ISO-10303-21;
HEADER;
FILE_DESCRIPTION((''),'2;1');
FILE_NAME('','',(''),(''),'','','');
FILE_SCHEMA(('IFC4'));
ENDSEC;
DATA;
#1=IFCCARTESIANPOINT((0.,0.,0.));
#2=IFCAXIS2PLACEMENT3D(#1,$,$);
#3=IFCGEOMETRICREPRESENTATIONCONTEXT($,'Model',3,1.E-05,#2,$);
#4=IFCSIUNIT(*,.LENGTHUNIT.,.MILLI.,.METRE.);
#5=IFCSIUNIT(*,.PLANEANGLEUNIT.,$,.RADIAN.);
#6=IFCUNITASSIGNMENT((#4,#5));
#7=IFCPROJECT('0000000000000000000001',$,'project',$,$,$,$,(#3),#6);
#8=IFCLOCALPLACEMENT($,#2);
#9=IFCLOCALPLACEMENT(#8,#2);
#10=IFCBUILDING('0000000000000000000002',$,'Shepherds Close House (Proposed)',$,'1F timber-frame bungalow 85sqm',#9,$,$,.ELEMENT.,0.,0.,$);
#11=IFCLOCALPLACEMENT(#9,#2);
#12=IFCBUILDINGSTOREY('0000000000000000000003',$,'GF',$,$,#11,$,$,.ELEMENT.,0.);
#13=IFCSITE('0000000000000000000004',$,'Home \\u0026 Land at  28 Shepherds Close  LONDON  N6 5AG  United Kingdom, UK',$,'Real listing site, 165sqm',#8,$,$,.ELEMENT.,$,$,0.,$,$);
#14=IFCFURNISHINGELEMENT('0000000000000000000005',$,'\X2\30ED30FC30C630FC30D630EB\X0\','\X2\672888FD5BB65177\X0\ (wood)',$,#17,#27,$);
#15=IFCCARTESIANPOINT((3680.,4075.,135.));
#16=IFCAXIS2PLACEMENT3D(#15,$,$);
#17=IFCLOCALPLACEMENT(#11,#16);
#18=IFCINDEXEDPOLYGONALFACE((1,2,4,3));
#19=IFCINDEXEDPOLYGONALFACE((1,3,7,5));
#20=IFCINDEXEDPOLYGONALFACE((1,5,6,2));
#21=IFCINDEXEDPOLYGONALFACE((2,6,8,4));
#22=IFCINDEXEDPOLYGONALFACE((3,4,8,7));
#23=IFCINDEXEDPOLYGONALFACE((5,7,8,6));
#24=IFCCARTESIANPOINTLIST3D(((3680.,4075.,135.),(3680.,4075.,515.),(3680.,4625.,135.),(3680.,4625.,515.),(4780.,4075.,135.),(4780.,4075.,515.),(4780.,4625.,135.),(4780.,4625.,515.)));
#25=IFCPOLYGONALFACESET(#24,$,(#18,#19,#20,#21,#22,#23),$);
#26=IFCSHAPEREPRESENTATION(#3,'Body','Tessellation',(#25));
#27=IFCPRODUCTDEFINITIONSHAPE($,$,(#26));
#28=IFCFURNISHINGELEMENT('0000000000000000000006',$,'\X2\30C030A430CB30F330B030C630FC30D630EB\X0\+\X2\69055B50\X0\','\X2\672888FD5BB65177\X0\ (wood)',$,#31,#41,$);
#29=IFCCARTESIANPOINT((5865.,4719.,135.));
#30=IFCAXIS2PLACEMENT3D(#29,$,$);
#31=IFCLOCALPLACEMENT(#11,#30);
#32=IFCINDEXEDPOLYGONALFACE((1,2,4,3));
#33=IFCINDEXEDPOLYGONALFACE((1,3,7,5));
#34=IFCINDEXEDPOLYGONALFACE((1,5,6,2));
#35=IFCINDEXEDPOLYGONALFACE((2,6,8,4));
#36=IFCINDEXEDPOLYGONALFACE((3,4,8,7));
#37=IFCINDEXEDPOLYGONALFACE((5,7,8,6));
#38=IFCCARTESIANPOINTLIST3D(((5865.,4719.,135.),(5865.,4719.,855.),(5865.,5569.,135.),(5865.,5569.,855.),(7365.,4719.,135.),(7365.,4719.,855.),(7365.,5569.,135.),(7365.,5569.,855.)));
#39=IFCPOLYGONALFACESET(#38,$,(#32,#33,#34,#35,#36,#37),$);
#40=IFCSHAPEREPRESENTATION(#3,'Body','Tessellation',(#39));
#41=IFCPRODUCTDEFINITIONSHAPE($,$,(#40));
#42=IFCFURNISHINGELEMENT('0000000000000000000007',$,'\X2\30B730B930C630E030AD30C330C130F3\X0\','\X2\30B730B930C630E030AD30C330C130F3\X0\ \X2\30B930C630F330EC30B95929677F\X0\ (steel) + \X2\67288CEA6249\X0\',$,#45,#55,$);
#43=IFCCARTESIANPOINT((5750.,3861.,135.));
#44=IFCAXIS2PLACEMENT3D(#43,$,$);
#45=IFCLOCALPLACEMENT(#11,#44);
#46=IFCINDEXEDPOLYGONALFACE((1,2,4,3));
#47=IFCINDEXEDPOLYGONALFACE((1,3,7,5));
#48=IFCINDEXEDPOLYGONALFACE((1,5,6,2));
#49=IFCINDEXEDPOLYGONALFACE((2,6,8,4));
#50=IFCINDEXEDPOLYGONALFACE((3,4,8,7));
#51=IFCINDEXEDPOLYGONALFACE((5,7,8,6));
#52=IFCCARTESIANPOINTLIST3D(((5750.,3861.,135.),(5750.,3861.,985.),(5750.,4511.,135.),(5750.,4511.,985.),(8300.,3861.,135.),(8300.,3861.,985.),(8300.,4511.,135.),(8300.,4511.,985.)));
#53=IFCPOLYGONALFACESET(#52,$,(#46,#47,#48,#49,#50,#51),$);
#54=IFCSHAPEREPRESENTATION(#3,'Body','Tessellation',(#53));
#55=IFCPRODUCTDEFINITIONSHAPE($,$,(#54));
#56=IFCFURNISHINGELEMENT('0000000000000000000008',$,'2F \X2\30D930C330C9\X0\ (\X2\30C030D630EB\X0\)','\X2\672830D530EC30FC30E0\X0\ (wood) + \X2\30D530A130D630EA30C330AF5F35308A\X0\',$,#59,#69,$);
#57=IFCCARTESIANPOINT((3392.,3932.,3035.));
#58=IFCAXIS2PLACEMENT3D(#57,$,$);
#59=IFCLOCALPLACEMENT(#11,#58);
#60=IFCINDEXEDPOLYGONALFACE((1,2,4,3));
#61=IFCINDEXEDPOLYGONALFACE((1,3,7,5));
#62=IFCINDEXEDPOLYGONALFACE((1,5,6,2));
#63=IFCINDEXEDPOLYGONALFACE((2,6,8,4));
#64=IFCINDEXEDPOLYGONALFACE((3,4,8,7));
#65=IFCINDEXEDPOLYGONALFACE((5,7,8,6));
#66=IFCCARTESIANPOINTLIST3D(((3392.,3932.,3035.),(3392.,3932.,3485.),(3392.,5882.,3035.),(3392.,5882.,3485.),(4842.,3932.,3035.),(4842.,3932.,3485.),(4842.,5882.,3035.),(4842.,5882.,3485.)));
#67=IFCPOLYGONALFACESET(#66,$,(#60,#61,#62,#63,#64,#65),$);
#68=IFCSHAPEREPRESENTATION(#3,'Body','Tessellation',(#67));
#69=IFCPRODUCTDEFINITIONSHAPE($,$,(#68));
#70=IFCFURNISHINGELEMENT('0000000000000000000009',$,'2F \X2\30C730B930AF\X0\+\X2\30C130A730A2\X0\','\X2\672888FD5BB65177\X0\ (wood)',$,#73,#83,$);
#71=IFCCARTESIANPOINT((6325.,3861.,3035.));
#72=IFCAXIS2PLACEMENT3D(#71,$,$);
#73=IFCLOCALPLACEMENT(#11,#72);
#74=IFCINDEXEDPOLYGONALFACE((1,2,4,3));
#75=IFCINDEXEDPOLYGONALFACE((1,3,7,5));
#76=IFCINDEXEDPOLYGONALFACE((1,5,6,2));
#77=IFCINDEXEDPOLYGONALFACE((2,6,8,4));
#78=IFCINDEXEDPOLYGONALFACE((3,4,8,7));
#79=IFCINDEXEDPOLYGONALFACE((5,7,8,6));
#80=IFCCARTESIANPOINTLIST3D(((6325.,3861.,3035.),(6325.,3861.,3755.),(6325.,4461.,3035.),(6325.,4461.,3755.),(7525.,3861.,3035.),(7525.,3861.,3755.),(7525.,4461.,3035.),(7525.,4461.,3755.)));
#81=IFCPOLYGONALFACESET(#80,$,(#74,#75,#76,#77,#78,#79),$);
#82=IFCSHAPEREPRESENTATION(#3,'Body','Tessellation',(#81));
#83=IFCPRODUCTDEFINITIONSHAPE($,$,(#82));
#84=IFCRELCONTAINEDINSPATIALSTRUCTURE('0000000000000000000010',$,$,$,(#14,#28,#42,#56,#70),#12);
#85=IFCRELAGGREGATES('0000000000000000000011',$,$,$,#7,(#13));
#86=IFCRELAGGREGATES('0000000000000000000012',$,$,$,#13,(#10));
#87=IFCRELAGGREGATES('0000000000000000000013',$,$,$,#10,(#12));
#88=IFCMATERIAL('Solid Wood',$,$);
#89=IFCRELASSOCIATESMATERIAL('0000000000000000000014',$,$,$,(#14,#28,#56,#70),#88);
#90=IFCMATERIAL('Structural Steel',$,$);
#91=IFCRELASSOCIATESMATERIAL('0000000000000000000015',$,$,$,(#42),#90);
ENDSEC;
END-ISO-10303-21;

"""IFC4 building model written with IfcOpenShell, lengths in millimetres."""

from ifc_helpers import new_model, si_unit, frame, frame_2d, origin, place, context, project, spatial, rectangle, extrude, material, element, save


model = new_model("IFC4")

# Units and contexts
model_context = context("Model", 3, precision=1e-05, world=origin())
ifc_project = project(units=[si_unit("LENGTHUNIT", "METRE", prefix="MILLI"), si_unit("PLANEANGLEUNIT", "RADIAN")], contexts=[model_context])

# Site, building, storey
site_placement = place(None, origin())
site = spatial("IfcSite", under=ifc_project, at=site_placement, Name="Home \\u0026 Land at  28 Shepherds Close  LONDON  N6 5AG  United Kingdom, UK", ObjectType="Real listing site, 165sqm", CompositionType="ELEMENT", RefElevation=0.0)
building_placement = place(site_placement, origin())
building = spatial("IfcBuilding", under=site, at=building_placement, Name="Shepherds Close House (Proposed)", ObjectType="1F timber-frame bungalow 85sqm", CompositionType="ELEMENT", ElevationOfRefHeight=0.0, ElevationOfTerrain=0.0)
storey_placement = place(building_placement, origin())
storey = spatial("IfcBuildingStorey", under=building, at=storey_placement, Name="GF", CompositionType="ELEMENT", Elevation=0.0)

# Shared definitions
ifc_material_1 = material(Name="Solid Wood")

# Shared definitions
ifc_material_2 = material(Name="Structural Steel")

# Furnishing elements
furnishing_1_placement = place(storey_placement, frame((3680.0, 4075.0, 135.0)))
element("IfcFurnishingElement", 1, at=furnishing_1_placement, inside=storey, material=ifc_material_1, Name="ローテーブル", Description="木製家具 (wood)", context=model_context, shape_type="SweptSolid", body=[
    extrude(rectangle(XDim=1100.0, YDim=550.0, at=frame_2d((550.0, 275.0))), frame((3680.0, 4075.0, 135.0)), (0.0, 0.0, 1.0), 380.0),
])
furnishing_2_placement = place(storey_placement, frame((5865.0, 4719.0, 135.0)))
element("IfcFurnishingElement", 2, at=furnishing_2_placement, inside=storey, material=ifc_material_1, Name="ダイニングテーブル+椅子", Description="木製家具 (wood)", context=model_context, shape_type="SweptSolid", body=[
    extrude(rectangle(XDim=1500.0, YDim=850.0, at=frame_2d((750.0, 425.0))), frame((5865.0, 4719.0, 135.0)), (0.0, 0.0, 1.0), 720.0),
])
furnishing_3_placement = place(storey_placement, frame((5750.0, 3861.0, 135.0)))
element("IfcFurnishingElement", 3, at=furnishing_3_placement, inside=storey, material=ifc_material_2, Name="システムキッチン", Description="システムキッチン ステンレス天板 (steel) + 木質扉", context=model_context, shape_type="SweptSolid", body=[
    extrude(rectangle(XDim=2550.0, YDim=650.0, at=frame_2d((1275.0, 325.0))), frame((5750.0, 3861.0, 135.0)), (0.0, 0.0, 1.0), 850.0),
])
furnishing_4_placement = place(storey_placement, frame((3392.0, 3932.0, 3035.0)))
element("IfcFurnishingElement", 4, at=furnishing_4_placement, inside=storey, material=ifc_material_1, Name="2F ベッド (ダブル)", Description="木フレーム (wood) + ファブリック張り", context=model_context, shape_type="SweptSolid", body=[
    extrude(rectangle(XDim=1450.0, YDim=1950.0, at=frame_2d((725.0, 975.0))), frame((3392.0, 3932.0, 3035.0)), (0.0, 0.0, 1.0), 450.0),
])
furnishing_5_placement = place(storey_placement, frame((6325.0, 3861.0, 3035.0)))
element("IfcFurnishingElement", 5, at=furnishing_5_placement, inside=storey, material=ifc_material_1, Name="2F デスク+チェア", Description="木製家具 (wood)", context=model_context, shape_type="SweptSolid", body=[
    extrude(rectangle(XDim=1200.0, YDim=600.0, at=frame_2d((600.0, 300.0))), frame((6325.0, 3861.0, 3035.0)), (0.0, 0.0, 1.0), 720.0),
])

save(model, "model.ifc")
